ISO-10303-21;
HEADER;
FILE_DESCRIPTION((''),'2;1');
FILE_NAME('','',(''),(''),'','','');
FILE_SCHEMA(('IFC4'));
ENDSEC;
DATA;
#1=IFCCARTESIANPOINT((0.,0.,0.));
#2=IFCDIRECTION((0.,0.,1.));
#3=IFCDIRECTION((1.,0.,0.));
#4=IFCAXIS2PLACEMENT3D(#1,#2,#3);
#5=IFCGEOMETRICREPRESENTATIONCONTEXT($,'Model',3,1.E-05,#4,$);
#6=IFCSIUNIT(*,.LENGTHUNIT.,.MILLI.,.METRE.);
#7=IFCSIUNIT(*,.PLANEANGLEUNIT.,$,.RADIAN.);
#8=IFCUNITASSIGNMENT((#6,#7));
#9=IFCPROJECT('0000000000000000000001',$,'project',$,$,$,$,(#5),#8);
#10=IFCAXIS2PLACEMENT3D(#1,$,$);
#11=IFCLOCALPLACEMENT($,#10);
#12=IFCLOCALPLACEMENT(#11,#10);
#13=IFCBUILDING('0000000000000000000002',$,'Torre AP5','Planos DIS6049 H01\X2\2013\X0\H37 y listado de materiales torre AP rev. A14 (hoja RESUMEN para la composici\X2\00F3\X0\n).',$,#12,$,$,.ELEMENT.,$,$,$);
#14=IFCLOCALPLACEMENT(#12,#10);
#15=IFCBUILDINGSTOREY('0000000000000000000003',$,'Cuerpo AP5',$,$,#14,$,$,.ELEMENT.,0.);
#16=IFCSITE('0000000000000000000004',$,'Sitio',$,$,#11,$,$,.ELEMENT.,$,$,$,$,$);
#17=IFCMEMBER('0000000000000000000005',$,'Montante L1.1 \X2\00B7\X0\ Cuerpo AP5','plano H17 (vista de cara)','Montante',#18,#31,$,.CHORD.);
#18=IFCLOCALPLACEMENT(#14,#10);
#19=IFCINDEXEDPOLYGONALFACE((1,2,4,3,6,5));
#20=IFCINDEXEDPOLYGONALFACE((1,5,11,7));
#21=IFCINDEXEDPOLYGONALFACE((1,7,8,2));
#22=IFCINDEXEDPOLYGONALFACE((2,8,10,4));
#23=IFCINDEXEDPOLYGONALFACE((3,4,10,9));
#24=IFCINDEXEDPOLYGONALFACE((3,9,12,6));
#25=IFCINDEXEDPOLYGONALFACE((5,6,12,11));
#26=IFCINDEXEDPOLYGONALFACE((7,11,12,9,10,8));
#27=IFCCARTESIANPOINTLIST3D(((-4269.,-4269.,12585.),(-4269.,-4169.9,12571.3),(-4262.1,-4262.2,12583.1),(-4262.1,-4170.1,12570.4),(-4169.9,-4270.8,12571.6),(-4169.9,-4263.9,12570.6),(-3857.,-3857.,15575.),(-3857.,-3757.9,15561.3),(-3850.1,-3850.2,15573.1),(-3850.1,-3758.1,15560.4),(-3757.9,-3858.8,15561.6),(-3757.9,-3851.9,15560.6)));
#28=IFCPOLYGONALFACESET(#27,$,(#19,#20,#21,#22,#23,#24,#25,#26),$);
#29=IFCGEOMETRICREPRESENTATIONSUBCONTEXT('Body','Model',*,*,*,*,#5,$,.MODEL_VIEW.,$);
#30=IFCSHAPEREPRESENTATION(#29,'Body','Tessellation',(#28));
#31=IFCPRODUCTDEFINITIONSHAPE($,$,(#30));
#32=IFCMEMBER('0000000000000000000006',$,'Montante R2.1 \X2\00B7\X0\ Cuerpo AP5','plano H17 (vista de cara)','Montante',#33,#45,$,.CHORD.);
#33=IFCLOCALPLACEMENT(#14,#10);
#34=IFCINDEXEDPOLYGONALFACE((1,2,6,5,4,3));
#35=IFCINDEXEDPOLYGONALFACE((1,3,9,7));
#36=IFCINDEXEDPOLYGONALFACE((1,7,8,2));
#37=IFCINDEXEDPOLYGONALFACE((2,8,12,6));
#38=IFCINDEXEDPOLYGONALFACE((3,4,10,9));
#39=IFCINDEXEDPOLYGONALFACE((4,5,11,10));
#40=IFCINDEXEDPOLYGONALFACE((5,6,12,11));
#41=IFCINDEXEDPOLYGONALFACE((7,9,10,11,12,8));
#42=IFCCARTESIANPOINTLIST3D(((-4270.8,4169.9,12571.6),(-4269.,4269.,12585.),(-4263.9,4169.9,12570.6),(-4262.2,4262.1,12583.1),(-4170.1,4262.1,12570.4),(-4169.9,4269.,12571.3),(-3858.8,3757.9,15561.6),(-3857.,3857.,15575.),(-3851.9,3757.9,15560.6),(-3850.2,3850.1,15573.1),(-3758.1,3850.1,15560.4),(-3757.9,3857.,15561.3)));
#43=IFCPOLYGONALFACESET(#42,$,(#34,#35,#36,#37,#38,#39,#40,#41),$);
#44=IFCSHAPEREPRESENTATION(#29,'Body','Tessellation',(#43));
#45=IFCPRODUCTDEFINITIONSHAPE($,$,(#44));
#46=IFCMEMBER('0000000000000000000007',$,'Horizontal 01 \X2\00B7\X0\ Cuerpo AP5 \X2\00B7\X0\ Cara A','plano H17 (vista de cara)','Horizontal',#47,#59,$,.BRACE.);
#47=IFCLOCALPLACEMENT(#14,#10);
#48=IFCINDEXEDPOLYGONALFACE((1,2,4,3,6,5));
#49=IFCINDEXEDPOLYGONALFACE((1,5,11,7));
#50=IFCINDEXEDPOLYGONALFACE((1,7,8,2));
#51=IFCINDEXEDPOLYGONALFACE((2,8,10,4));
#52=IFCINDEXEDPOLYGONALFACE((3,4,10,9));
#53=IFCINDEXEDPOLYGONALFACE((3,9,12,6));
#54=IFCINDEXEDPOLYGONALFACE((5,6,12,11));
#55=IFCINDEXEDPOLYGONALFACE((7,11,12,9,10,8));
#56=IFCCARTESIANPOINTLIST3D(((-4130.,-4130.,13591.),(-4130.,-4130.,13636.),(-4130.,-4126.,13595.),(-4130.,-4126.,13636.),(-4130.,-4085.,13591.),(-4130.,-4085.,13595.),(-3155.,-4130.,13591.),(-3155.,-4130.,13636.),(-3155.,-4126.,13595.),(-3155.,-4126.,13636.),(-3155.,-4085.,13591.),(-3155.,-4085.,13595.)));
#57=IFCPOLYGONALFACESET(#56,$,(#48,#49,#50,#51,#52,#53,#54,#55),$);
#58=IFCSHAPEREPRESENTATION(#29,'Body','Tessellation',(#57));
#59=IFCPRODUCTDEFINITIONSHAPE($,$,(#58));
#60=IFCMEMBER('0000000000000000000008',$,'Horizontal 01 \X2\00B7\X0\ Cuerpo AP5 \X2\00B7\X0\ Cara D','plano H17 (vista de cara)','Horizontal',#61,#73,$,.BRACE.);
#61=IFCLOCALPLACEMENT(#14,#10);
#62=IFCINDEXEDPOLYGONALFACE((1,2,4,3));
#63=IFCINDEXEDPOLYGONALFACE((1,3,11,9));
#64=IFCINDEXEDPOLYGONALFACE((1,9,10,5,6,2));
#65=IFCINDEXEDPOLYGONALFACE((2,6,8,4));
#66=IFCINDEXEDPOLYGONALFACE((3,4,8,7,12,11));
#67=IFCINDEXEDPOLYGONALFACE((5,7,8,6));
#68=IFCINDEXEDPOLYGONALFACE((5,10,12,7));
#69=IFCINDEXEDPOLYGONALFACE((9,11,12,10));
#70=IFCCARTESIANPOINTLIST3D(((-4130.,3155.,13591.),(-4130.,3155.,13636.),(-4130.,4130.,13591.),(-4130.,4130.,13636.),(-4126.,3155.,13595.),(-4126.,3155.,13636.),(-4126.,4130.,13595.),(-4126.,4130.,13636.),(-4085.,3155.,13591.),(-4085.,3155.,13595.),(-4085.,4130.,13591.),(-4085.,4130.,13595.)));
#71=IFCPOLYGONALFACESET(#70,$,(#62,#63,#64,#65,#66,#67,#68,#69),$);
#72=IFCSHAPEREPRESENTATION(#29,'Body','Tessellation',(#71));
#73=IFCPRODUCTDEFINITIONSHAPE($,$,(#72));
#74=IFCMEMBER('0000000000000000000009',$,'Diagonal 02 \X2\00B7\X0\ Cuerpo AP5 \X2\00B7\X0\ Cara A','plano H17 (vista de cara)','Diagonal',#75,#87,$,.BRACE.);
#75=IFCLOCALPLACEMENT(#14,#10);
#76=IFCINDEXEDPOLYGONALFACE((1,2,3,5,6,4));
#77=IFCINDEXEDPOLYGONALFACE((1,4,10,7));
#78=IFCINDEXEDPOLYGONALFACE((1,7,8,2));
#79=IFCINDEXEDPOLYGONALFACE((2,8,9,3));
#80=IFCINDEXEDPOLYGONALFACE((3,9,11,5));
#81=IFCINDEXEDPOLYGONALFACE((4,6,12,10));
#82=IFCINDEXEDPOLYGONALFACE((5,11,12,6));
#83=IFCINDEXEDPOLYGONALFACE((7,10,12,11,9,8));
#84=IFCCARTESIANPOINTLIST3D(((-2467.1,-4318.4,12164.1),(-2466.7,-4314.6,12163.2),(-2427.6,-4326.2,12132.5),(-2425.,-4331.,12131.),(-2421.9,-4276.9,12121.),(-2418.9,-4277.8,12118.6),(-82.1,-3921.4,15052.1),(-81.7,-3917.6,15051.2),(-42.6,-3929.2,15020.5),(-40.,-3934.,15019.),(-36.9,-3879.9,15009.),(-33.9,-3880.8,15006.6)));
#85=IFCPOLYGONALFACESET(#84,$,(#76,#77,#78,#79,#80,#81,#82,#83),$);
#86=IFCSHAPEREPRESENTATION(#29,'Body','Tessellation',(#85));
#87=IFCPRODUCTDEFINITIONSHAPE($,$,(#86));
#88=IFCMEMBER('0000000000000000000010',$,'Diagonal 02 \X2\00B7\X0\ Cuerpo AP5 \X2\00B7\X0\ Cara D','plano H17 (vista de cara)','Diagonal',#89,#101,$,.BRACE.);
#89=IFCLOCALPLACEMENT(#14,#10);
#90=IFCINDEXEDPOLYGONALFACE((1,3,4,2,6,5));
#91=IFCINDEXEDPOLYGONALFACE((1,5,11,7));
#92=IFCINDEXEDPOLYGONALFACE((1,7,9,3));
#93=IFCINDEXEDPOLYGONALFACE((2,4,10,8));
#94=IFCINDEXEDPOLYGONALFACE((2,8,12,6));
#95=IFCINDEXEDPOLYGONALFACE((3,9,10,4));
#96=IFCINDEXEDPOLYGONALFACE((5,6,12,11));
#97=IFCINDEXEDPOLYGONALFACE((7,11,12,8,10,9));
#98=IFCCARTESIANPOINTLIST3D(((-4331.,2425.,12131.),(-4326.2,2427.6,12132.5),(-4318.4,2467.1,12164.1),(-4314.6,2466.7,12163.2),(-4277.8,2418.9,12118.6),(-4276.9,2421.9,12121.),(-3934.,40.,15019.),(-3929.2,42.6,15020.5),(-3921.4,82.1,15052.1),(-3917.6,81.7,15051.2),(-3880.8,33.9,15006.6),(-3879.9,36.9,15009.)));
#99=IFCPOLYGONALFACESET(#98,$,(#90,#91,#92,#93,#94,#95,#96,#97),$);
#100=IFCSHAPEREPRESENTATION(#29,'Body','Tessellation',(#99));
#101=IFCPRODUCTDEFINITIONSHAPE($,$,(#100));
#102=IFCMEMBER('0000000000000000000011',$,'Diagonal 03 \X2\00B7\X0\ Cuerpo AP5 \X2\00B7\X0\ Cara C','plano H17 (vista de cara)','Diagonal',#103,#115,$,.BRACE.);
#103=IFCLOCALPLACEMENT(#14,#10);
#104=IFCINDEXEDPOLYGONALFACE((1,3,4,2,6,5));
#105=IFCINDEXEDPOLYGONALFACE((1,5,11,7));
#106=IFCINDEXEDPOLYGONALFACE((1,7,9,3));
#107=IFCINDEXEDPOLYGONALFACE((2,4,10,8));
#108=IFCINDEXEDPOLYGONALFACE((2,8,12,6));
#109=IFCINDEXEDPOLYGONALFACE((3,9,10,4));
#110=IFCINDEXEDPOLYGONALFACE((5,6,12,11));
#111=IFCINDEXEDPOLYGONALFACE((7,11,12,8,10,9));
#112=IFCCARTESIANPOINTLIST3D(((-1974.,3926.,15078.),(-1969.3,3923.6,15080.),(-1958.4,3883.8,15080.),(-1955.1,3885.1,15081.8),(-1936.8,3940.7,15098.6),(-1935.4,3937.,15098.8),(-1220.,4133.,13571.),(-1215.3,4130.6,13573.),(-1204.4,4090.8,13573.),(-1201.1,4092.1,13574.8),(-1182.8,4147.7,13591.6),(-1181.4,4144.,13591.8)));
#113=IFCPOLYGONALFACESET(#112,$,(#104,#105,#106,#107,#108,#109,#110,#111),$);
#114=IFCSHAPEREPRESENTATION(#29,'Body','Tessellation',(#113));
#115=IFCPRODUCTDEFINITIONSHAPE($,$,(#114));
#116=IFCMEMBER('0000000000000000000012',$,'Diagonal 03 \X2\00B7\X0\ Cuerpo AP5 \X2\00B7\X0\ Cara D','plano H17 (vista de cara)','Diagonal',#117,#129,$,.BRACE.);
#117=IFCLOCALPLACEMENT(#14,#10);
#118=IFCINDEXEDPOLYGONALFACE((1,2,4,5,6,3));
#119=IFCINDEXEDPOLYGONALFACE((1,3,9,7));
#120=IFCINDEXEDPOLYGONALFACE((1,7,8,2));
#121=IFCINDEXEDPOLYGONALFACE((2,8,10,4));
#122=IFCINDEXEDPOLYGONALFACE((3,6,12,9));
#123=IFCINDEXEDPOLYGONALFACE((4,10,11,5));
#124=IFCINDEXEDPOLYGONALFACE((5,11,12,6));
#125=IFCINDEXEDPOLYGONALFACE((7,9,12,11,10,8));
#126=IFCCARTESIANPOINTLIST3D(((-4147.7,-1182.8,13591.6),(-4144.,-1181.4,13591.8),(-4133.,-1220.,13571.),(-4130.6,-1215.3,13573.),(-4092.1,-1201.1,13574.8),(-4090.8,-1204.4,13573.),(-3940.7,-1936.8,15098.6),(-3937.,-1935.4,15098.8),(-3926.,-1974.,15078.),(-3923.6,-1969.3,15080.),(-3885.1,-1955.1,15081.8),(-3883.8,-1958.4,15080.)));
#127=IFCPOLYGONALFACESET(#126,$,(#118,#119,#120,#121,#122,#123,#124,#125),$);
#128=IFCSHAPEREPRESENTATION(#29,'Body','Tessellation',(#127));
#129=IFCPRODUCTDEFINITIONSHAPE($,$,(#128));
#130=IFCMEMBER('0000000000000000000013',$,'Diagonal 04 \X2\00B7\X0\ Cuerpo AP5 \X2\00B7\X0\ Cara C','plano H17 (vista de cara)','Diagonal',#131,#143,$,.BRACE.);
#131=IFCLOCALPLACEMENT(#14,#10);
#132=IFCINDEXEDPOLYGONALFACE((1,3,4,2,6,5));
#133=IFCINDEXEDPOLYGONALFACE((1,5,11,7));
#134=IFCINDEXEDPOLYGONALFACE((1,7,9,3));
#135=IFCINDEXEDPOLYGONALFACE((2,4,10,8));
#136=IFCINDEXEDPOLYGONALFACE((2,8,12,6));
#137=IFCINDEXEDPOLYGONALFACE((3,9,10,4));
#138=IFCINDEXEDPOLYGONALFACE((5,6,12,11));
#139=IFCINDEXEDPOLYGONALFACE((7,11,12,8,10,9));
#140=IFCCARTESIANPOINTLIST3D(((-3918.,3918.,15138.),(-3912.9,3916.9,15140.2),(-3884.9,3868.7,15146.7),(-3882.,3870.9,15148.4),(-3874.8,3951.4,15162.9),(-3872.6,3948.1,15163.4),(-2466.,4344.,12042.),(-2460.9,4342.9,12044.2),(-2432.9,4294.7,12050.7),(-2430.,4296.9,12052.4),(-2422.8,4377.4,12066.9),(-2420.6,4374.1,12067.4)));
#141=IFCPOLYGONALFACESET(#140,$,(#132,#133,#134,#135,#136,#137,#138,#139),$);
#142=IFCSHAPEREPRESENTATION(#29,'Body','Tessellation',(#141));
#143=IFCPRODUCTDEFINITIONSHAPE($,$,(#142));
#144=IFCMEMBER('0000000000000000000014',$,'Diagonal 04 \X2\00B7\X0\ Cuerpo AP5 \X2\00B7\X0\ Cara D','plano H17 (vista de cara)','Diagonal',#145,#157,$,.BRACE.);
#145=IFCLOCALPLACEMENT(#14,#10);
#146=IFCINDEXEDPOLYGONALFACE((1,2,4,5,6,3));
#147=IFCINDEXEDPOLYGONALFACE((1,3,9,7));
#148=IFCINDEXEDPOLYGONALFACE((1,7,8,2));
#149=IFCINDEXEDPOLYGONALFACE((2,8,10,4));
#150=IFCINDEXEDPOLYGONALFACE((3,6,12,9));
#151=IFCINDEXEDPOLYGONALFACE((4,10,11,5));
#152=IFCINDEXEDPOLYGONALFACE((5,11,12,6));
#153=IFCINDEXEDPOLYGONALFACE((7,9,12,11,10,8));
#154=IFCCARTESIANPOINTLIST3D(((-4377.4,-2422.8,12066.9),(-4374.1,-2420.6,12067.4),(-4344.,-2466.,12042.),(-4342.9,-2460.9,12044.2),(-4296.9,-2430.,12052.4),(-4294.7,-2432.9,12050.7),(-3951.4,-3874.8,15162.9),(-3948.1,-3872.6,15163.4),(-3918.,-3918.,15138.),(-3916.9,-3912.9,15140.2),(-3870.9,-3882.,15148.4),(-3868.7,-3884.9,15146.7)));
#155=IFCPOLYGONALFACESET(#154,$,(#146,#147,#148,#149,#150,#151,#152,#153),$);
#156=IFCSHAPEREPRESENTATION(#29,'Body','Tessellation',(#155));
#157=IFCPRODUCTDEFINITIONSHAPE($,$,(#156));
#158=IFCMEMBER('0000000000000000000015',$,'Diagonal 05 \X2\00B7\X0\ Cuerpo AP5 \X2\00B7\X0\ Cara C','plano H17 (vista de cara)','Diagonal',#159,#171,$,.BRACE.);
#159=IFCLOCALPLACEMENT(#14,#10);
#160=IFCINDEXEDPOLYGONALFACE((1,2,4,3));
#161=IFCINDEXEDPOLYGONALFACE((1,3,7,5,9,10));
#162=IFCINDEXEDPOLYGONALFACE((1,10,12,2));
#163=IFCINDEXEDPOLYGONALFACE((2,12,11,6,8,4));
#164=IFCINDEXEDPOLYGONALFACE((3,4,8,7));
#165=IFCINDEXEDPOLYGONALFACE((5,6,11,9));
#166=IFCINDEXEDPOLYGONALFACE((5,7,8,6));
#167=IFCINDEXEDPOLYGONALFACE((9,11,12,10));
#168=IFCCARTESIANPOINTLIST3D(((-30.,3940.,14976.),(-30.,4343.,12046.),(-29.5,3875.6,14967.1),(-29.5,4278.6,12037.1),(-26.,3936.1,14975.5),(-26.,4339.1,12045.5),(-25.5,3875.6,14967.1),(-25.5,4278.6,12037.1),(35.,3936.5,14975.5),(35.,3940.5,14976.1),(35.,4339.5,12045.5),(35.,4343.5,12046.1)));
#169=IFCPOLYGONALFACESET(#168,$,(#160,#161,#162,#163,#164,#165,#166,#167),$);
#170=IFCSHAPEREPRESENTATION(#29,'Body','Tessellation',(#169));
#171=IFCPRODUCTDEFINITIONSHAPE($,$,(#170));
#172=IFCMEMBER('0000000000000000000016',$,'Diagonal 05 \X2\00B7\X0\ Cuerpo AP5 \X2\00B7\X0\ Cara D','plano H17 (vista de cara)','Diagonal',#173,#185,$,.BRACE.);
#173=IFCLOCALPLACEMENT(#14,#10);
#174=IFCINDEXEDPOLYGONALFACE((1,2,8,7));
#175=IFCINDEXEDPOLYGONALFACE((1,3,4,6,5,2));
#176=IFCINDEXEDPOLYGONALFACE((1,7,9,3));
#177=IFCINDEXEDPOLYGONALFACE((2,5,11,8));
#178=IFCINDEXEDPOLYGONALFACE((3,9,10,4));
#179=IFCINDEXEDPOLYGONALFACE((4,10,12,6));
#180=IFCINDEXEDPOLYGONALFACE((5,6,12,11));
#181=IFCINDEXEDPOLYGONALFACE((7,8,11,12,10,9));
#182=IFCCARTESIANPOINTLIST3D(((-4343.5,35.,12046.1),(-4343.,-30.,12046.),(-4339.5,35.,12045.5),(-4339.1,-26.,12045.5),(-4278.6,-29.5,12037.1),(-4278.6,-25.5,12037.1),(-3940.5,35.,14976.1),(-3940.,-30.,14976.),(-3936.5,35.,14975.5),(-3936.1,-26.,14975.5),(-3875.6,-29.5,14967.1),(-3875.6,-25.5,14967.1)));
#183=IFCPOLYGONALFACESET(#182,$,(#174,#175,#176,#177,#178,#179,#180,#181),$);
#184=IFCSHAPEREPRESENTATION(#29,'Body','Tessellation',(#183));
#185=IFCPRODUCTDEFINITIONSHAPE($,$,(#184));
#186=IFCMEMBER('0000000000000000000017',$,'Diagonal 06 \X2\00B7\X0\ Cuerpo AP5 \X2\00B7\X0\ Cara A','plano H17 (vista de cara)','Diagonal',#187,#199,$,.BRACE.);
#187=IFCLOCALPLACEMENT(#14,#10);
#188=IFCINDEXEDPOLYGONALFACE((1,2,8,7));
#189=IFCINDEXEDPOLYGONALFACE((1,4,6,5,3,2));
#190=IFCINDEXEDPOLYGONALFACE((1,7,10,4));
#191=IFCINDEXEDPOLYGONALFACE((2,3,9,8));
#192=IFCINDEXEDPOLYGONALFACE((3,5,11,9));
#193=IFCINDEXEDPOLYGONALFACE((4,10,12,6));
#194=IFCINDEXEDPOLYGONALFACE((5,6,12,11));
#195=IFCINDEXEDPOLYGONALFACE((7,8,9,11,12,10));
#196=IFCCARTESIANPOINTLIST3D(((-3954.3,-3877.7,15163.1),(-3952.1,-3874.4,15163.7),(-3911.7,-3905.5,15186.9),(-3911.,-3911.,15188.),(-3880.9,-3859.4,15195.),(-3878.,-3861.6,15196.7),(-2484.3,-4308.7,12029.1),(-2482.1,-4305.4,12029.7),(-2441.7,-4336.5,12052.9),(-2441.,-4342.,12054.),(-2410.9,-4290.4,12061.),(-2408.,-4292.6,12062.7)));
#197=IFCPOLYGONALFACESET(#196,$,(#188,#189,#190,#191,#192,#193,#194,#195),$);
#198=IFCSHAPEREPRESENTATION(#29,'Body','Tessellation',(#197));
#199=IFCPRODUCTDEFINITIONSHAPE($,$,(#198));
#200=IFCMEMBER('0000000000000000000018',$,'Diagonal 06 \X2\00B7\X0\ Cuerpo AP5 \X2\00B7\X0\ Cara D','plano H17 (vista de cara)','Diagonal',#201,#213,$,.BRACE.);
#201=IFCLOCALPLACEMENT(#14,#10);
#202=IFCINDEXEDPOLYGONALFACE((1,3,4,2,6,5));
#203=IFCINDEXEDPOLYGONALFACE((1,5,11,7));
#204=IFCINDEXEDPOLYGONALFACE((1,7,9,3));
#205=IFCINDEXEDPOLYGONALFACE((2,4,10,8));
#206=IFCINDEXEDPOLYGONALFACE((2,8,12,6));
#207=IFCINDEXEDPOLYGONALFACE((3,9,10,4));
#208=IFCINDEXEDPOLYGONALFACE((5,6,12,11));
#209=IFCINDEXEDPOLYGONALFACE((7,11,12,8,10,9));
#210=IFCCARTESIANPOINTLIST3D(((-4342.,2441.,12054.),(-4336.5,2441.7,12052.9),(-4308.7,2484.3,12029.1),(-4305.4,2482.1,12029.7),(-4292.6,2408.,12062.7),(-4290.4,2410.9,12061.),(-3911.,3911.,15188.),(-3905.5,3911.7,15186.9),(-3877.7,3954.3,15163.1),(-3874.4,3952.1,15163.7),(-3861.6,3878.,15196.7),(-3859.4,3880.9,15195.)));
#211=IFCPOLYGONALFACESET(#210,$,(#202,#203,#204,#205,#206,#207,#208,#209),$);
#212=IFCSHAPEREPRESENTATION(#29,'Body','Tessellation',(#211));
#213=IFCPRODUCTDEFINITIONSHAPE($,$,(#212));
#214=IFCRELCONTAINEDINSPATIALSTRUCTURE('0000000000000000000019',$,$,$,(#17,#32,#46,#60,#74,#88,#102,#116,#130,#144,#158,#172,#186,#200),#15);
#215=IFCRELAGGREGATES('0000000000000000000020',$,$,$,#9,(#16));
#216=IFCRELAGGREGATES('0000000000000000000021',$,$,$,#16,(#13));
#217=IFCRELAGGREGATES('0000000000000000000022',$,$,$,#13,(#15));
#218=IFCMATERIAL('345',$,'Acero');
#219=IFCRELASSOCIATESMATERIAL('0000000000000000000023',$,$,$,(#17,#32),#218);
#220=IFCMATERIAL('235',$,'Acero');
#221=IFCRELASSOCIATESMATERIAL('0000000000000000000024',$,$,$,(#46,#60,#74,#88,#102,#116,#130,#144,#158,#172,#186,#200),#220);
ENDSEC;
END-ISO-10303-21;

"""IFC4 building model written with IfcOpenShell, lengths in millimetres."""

from ifc_helpers import new_model, si_unit, frame, frame_2d, origin, origin_with_axes, place, context, subcontext, project, spatial, l_section, extrude, material, element, save


model = new_model("IFC4")

# Units and contexts
model_context = context("Model", 3, precision=1e-05, world=origin_with_axes())
body_context = subcontext(model_context, "Body", "Model", "MODEL_VIEW")
ifc_project = project(units=[si_unit("LENGTHUNIT", "METRE", prefix="MILLI"), si_unit("PLANEANGLEUNIT", "RADIAN")], contexts=[model_context])

# Site, building, storey
site_placement = place(None, origin())
site = spatial("IfcSite", under=ifc_project, at=site_placement, Name="Sitio", CompositionType="ELEMENT")
building_placement = place(site_placement, origin())
building = spatial("IfcBuilding", under=site, at=building_placement, Name="Torre AP5", Description="Planos DIS6049 H01–H37 y listado de materiales torre AP rev. A14 (hoja RESUMEN para la composición).", CompositionType="ELEMENT")
storey_placement = place(building_placement, origin())
storey = spatial("IfcBuildingStorey", under=building, at=storey_placement, Name="Cuerpo AP5", CompositionType="ELEMENT", Elevation=0.0)

# Members
ifc_material_1 = material(Name="345", Category="Acero")
for number, where, z_axis, x_axis, name in (
    (1, (-4269.0, -4269.0, 12585.0), (0.135249, 0.135249, 0.981537), (0.990812, -0.018462, -0.133983), "Montante L1.1 · Cuerpo AP5"),
    (2, (-4269.0, 4269.0, 12585.0), (0.135249, -0.135249, 0.981537), (-0.018462, -0.990812, -0.133983), "Montante R2.1 · Cuerpo AP5"),
):
    element("IfcMember", number, at=place(storey_placement, frame(where, z_axis=z_axis, x_axis=x_axis)), inside=storey, material=ifc_material_1, Name=name, Description="plano H17 (vista de cara)", ObjectType="Montante", PredefinedType="CHORD", context=body_context, shape_type="SweptSolid", body=[
        extrude(l_section(Depth=100.0, Width=100.0, Thickness=7.0, at=frame_2d((50.0, 50.0))), None, (0.0, 0.0, 1.0), 3046.2),
    ])
ifc_material_2 = material(Name="235", Category="Acero")
for number, where, z_axis, x_axis, name in (
    (3, (-4130.0, -4130.0, 13591.0), (1.0, 0.0, 0.0), (0.0, 1.0, 0.0), "Horizontal 01 · Cuerpo AP5 · Cara A"),
    (4, (-4130.0, 4130.0, 13591.0), (0.0, -1.0, 0.0), (1.0, 0.0, 0.0), "Horizontal 01 · Cuerpo AP5 · Cara D"),
):
    element("IfcMember", number, at=place(storey_placement, frame(where, z_axis=z_axis, x_axis=x_axis)), inside=storey, material=ifc_material_2, Name=name, Description="plano H17 (vista de cara)", ObjectType="Horizontal", PredefinedType="BRACE", context=body_context, shape_type="SweptSolid", body=[
        extrude(l_section(Depth=45.0, Width=45.0, Thickness=4.0, at=frame_2d((22.5, 22.5))), None, (0.0, 0.0, 1.0), 975.0),
    ])
for number, where, z_axis, x_axis, name in (
    (5, (-2425.0, -4331.0, 12131.0), (0.633217, 0.105403, 0.766763), (0.111785, 0.967841, -0.22536), "Diagonal 02 · Cuerpo AP5 · Cara A"),
    (6, (-4331.0, 2425.0, 12131.0), (0.105403, -0.633217, 0.766763), (0.967841, -0.111785, -0.22536), "Diagonal 02 · Cuerpo AP5 · Cara D"),
):
    element("IfcMember", number, at=place(storey_placement, frame(where, z_axis=z_axis, x_axis=x_axis)), inside=storey, material=ifc_material_2, Name=name, Description="plano H17 (vista de cara)", ObjectType="Diagonal", PredefinedType="BRACE", context=body_context, shape_type="SweptSolid", body=[
        extrude(l_section(Depth=55.0, Width=55.0, Thickness=4.0, at=frame_2d((27.5, 27.5))), None, (0.0, 0.0, 1.0), 3766.5),
    ])
for number, where, z_axis, x_axis, name in (
    (7, (-1220.0, 4133.0, 13571.0), (-0.444113, -0.121925, 0.887636), (0.346552, -0.936966, 0.04469), "Diagonal 03 · Cuerpo AP5 · Cara C"),
    (8, (-4133.0, -1220.0, 13571.0), (0.121925, -0.444113, 0.887636), (0.936966, 0.346552, 0.04469), "Diagonal 03 · Cuerpo AP5 · Cara D"),
):
    element("IfcMember", number, at=place(storey_placement, frame(where, z_axis=z_axis, x_axis=x_axis)), inside=storey, material=ifc_material_2, Name=name, Description="plano H17 (vista de cara)", ObjectType="Diagonal", PredefinedType="BRACE", context=body_context, shape_type="SweptSolid", body=[
        extrude(l_section(Depth=45.0, Width=45.0, Thickness=4.0, at=frame_2d((22.5, 22.5))), None, (0.0, 0.0, 1.0), 1697.8),
    ])
for number, where, z_axis, x_axis, name in (
    (9, (-2466.0, 4344.0, 12042.0), (-0.421357, -0.123621, 0.89843), (0.551178, -0.821613, 0.145447), "Diagonal 04 · Cuerpo AP5 · Cara C"),
    (10, (-4344.0, -2466.0, 12042.0), (0.123621, -0.421357, 0.89843), (0.821613, 0.551178, 0.145447), "Diagonal 04 · Cuerpo AP5 · Cara D"),
):
    element("IfcMember", number, at=place(storey_placement, frame(where, z_axis=z_axis, x_axis=x_axis)), inside=storey, material=ifc_material_2, Name=name, Description="plano H17 (vista de cara)", ObjectType="Diagonal", PredefinedType="BRACE", context=body_context, shape_type="SweptSolid", body=[
        extrude(l_section(Depth=60.0, Width=60.0, Thickness=4.0, at=frame_2d((30.0, 30.0))), None, (0.0, 0.0, 1.0), 3446.0),
    ])
for number, where, z_axis, x_axis, name in (
    (11, (-30.0, 4343.0, 12046.0), (0.0, -0.13626, 0.990673), (0.007312, -0.990647, -0.136256), "Diagonal 05 · Cuerpo AP5 · Cara C"),
    (12, (-4343.0, -30.0, 12046.0), (0.13626, 0.0, 0.990673), (0.990647, 0.007312, -0.136256), "Diagonal 05 · Cuerpo AP5 · Cara D"),
):
    element("IfcMember", number, at=place(storey_placement, frame(where, z_axis=z_axis, x_axis=x_axis)), inside=storey, material=ifc_material_2, Name=name, Description="plano H17 (vista de cara)", ObjectType="Diagonal", PredefinedType="BRACE", context=body_context, shape_type="SweptSolid", body=[
        extrude(l_section(Depth=65.0, Width=65.0, Thickness=4.0, at=frame_2d((32.5, 32.5))), None, (0.0, 0.0, 1.0), 2957.6),
    ])
for number, where, z_axis, x_axis, name in (
    (13, (-2441.0, -4342.0, 12054.0), (-0.421402, 0.123554, 0.898418), (0.549879, 0.822598, 0.144793), "Diagonal 06 · Cuerpo AP5 · Cara A"),
    (14, (-4342.0, 2441.0, 12054.0), (0.123554, 0.421402, 0.898418), (0.822598, -0.549879, 0.144793), "Diagonal 06 · Cuerpo AP5 · Cara D"),
):
    element("IfcMember", number, at=place(storey_placement, frame(where, z_axis=z_axis, x_axis=x_axis)), inside=storey, material=ifc_material_2, Name=name, Description="plano H17 (vista de cara)", ObjectType="Diagonal", PredefinedType="BRACE", context=body_context, shape_type="SweptSolid", body=[
        extrude(l_section(Depth=60.0, Width=60.0, Thickness=4.0, at=frame_2d((30.0, 30.0))), None, (0.0, 0.0, 1.0), 3488.4),
    ])

save(model, "model.ifc")
